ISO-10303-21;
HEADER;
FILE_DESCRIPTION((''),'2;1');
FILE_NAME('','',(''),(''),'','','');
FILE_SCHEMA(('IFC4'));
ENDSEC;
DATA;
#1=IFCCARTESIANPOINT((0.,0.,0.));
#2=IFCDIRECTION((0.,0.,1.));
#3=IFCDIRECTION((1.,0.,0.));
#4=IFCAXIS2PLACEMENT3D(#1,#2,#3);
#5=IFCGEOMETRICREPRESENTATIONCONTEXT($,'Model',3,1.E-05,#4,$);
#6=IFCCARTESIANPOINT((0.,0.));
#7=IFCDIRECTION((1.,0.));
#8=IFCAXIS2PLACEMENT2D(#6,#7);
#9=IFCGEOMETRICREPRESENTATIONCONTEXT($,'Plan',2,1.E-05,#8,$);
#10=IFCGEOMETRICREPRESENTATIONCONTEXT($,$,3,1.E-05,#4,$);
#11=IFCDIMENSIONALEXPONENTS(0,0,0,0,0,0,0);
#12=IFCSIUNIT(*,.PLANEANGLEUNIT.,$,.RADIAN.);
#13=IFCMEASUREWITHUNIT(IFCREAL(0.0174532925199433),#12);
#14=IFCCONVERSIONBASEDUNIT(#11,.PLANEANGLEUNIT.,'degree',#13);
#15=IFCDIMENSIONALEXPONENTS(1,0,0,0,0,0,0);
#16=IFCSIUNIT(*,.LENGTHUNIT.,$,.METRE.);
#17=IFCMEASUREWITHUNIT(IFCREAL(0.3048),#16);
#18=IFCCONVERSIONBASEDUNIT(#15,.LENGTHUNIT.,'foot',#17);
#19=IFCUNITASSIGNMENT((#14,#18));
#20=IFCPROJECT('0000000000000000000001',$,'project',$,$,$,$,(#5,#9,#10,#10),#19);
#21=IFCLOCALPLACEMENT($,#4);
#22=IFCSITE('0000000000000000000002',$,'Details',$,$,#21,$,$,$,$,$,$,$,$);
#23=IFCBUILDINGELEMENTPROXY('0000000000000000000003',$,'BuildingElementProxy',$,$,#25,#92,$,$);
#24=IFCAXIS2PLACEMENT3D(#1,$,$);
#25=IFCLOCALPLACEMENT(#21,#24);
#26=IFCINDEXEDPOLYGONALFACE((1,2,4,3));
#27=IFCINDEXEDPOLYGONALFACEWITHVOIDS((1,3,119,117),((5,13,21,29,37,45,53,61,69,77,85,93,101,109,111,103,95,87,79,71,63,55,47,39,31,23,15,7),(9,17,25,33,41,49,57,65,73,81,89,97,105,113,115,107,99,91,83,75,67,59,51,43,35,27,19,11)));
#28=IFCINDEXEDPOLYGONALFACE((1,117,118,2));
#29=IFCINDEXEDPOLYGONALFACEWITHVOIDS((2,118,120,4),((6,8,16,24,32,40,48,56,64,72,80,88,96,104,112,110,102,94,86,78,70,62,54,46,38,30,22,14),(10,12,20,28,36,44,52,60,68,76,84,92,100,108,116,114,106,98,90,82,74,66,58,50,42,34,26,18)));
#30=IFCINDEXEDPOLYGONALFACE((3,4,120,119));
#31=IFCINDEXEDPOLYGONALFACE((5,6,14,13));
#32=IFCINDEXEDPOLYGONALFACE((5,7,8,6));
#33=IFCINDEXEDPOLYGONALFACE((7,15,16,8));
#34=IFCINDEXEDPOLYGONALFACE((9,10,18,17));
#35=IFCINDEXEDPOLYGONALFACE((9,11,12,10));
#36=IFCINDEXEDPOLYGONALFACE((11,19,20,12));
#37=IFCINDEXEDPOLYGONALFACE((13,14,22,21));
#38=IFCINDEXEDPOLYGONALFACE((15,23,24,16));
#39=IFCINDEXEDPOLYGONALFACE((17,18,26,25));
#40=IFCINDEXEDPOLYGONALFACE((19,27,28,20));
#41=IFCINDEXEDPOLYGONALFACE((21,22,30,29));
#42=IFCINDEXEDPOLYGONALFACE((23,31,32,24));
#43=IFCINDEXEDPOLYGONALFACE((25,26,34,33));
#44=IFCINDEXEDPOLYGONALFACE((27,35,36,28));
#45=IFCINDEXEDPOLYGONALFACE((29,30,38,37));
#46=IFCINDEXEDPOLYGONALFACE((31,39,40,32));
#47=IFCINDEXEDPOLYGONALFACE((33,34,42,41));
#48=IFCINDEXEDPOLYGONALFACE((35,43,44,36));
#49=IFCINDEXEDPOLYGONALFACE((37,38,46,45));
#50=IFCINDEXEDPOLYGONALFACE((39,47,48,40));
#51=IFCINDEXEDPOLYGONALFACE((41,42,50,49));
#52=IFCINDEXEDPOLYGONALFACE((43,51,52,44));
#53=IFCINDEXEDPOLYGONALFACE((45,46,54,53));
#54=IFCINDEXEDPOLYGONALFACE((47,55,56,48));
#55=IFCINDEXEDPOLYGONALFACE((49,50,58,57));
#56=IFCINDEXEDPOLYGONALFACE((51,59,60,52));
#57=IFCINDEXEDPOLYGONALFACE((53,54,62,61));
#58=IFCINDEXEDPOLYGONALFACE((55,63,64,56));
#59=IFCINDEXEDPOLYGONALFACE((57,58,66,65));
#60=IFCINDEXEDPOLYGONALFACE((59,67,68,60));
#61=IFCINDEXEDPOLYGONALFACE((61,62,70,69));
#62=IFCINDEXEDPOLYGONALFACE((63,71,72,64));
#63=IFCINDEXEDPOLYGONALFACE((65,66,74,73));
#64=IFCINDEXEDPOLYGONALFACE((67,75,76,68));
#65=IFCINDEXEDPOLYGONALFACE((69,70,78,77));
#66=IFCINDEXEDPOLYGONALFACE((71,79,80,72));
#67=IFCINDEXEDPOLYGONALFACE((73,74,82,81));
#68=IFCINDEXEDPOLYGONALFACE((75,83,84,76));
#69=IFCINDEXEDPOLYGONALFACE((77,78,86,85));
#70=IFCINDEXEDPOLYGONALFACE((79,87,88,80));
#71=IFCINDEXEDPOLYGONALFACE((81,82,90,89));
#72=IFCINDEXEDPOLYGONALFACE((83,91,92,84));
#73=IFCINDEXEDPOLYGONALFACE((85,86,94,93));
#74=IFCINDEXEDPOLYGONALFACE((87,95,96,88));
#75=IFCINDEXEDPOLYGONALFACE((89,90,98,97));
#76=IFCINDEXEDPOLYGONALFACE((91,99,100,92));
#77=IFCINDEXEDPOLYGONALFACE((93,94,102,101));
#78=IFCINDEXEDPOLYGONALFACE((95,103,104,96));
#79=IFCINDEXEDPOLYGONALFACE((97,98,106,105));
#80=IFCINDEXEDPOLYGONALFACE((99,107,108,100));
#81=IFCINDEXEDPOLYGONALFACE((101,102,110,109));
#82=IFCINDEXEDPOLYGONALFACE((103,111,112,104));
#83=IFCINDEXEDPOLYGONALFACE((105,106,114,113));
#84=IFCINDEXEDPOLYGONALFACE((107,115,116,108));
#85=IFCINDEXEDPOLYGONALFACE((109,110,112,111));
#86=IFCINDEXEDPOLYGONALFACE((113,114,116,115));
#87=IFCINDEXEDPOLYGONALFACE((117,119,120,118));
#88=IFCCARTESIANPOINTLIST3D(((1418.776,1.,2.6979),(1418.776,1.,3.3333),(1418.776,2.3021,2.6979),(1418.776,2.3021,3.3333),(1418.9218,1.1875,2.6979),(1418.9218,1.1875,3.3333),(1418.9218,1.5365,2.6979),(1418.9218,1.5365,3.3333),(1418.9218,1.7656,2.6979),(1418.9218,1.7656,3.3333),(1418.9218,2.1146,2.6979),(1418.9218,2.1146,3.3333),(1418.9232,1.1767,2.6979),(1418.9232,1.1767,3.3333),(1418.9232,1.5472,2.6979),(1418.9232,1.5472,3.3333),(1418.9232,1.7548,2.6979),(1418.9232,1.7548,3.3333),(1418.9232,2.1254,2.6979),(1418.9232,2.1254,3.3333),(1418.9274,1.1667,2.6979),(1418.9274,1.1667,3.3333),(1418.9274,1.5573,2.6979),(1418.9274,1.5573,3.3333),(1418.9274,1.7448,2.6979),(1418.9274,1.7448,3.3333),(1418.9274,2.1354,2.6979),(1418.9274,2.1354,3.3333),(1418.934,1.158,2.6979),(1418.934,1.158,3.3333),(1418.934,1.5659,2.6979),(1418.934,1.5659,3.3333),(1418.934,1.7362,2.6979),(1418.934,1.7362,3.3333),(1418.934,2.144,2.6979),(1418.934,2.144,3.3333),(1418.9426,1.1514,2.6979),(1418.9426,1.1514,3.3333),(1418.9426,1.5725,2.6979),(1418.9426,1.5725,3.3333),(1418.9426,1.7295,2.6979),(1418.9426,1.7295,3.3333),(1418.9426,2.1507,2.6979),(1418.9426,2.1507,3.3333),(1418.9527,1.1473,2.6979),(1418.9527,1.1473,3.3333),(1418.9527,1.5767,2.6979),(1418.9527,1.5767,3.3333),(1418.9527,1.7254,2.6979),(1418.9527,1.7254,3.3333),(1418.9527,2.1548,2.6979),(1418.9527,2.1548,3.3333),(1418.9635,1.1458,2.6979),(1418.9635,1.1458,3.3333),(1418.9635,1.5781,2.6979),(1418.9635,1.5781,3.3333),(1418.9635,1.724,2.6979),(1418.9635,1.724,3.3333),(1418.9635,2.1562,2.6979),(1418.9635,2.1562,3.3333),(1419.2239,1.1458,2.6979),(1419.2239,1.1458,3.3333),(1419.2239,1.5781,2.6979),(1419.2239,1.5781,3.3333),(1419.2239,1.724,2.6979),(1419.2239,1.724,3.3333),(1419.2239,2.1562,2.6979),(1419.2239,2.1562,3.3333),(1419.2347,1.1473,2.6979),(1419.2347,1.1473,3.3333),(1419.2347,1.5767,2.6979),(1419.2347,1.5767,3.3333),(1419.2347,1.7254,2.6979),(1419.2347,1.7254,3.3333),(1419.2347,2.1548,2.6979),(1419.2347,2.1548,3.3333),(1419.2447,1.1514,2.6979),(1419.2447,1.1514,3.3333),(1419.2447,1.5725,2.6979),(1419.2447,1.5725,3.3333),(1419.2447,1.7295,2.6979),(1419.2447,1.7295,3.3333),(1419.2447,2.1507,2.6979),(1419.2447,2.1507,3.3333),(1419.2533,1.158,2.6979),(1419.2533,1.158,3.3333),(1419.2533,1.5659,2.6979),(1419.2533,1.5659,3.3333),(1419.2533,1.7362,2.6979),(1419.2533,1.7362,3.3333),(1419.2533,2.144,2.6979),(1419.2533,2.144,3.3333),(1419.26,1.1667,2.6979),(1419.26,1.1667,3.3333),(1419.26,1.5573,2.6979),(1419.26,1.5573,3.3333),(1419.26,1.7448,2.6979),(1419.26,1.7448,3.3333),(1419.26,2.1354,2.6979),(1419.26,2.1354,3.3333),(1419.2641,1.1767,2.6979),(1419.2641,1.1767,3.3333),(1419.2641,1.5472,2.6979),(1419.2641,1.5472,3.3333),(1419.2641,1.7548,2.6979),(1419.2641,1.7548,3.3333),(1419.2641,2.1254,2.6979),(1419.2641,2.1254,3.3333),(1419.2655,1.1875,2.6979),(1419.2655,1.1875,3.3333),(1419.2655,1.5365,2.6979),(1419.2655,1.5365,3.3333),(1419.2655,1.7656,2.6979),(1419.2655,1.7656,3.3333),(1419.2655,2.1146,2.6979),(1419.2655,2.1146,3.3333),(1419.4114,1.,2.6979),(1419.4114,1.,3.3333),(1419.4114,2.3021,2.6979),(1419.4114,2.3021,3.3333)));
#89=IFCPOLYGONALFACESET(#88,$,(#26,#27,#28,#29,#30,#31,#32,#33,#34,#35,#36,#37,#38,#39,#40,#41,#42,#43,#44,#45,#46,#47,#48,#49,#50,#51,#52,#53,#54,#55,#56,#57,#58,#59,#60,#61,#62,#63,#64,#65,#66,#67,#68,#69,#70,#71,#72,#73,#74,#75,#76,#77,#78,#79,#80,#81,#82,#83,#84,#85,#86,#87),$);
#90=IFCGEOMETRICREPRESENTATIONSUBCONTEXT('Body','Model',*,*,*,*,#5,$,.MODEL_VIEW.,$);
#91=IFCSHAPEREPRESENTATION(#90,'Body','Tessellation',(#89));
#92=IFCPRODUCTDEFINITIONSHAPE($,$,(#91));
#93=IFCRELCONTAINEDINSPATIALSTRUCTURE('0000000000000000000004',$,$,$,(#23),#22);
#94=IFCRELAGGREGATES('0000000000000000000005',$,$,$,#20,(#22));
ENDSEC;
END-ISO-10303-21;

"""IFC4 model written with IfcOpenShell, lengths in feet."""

from ifc_helpers import new_model, entity, si_unit, converted_unit, frame, origin_with_axes, origin_2d_with_axis, place, context, subcontext, project, spatial, line, indexed_curve, outline, extrude, element, save


model = new_model("IFC4")

# Units and contexts
model_context = context("Model", 3, precision=1e-05, world=origin_with_axes())
plan_context = context("Plan", 2, precision=1e-05, world=origin_2d_with_axis())
context_of_model = context(None, 3, precision=1e-05, world=origin_with_axes())
body_context = subcontext(model_context, "Body", "Model", "MODEL_VIEW")
ifc_project = project(units=[converted_unit("PLANEANGLEUNIT", "degree", entity("IfcReal", 0.0174532925199433), si_unit("PLANEANGLEUNIT", "RADIAN"), dimensions=[0, 0, 0, 0, 0, 0, 0]), converted_unit("LENGTHUNIT", "foot", entity("IfcReal", 0.3048), si_unit("LENGTHUNIT", "METRE"), dimensions=[1, 0, 0, 0, 0, 0, 0])], contexts=[model_context, plan_context, context_of_model, context_of_model])

# Site
site_placement = place(None, origin_with_axes())
site = spatial("IfcSite", under=ifc_project, at=site_placement, Name="Details")

# Building element proxy
proxy_1_placement = place(site_placement, frame((1419.0936, 2.3021, 2.6979), z_axis=(0.0, 0.0, 1.0), x_axis=(0.0, 1.0, 0.0)))
element("IfcBuildingElementProxy", 1, at=proxy_1_placement, inside=site, Name="BuildingElementProxy", context=body_context, shape_type="SweptSolid", body=[
    extrude(outline(indexed_curve([(-0.3177, -0.651), (0.3177, -0.651), (0.3177, 0.651), (-0.3177, 0.651), (0.1719, -0.1146), (0.1719, -0.4635), (0.1705, -0.4743), (0.1663, -0.4844), (0.1597, -0.493), (0.151, -0.4996), (0.141, -0.5038), (0.1302, -0.5052), (-0.1302, -0.5052), (-0.141, -0.5038), (-0.151, -0.4996), (-0.1597, -0.493), (-0.1663, -0.4844), (-0.1705, -0.4743), (-0.1719, -0.4635), (-0.1719, -0.1146), (-0.1705, -0.1038), (-0.1663, -0.0938), (-0.1597, -0.0851), (-0.151, -0.0785), (-0.141, -0.0743), (-0.1302, -0.0729), (0.1302, -0.0729), (0.141, -0.0743), (0.151, -0.0785), (0.1597, -0.0851), (0.1663, -0.0938), (0.1705, -0.1038), (0.151, 0.0785), (0.141, 0.0743), (0.1302, 0.0729), (-0.1302, 0.0729), (-0.141, 0.0743), (-0.151, 0.0785), (-0.1597, 0.0851), (-0.1663, 0.0937), (-0.1705, 0.1038), (-0.1719, 0.1146), (-0.1719, 0.4635), (-0.1705, 0.4743), (-0.1663, 0.4844), (-0.1597, 0.493), (-0.151, 0.4996), (-0.141, 0.5038), (-0.1302, 0.5052), (0.1302, 0.5052), (0.141, 0.5038), (0.151, 0.4996), (0.1597, 0.493), (0.1663, 0.4844), (0.1705, 0.4743), (0.1719, 0.4635), (0.1719, 0.1146), (0.1705, 0.1038), (0.1663, 0.0937), (0.1597, 0.0851)], segments=[line(4, 3), line(3, 2), line(2, 1), line(1, 4)], self_intersect=False), holes=[indexed_curve([(-0.3177, -0.651), (0.3177, -0.651), (0.3177, 0.651), (-0.3177, 0.651), (0.1719, -0.1146), (0.1719, -0.4635), (0.1705, -0.4743), (0.1663, -0.4844), (0.1597, -0.493), (0.151, -0.4996), (0.141, -0.5038), (0.1302, -0.5052), (-0.1302, -0.5052), (-0.141, -0.5038), (-0.151, -0.4996), (-0.1597, -0.493), (-0.1663, -0.4844), (-0.1705, -0.4743), (-0.1719, -0.4635), (-0.1719, -0.1146), (-0.1705, -0.1038), (-0.1663, -0.0938), (-0.1597, -0.0851), (-0.151, -0.0785), (-0.141, -0.0743), (-0.1302, -0.0729), (0.1302, -0.0729), (0.141, -0.0743), (0.151, -0.0785), (0.1597, -0.0851), (0.1663, -0.0938), (0.1705, -0.1038), (0.151, 0.0785), (0.141, 0.0743), (0.1302, 0.0729), (-0.1302, 0.0729), (-0.141, 0.0743), (-0.151, 0.0785), (-0.1597, 0.0851), (-0.1663, 0.0937), (-0.1705, 0.1038), (-0.1719, 0.1146), (-0.1719, 0.4635), (-0.1705, 0.4743), (-0.1663, 0.4844), (-0.1597, 0.493), (-0.151, 0.4996), (-0.141, 0.5038), (-0.1302, 0.5052), (0.1302, 0.5052), (0.141, 0.5038), (0.151, 0.4996), (0.1597, 0.493), (0.1663, 0.4844), (0.1705, 0.4743), (0.1719, 0.4635), (0.1719, 0.1146), (0.1705, 0.1038), (0.1663, 0.0937), (0.1597, 0.0851)], segments=[line(20, 19), line(19, 18), line(18, 17), line(17, 16), line(16, 15), line(15, 14), line(14, 13), line(13, 12), line(12, 11), line(11, 10), line(10, 9), line(9, 8), line(8, 7), line(7, 6), line(6, 5), line(5, 32), line(32, 31), line(31, 30), line(30, 29), line(29, 28), line(28, 27), line(27, 26), line(26, 25), line(25, 24), line(24, 23), line(23, 22), line(22, 21), line(21, 20)], self_intersect=False), indexed_curve([(-0.3177, -0.651), (0.3177, -0.651), (0.3177, 0.651), (-0.3177, 0.651), (0.1719, -0.1146), (0.1719, -0.4635), (0.1705, -0.4743), (0.1663, -0.4844), (0.1597, -0.493), (0.151, -0.4996), (0.141, -0.5038), (0.1302, -0.5052), (-0.1302, -0.5052), (-0.141, -0.5038), (-0.151, -0.4996), (-0.1597, -0.493), (-0.1663, -0.4844), (-0.1705, -0.4743), (-0.1719, -0.4635), (-0.1719, -0.1146), (-0.1705, -0.1038), (-0.1663, -0.0938), (-0.1597, -0.0851), (-0.151, -0.0785), (-0.141, -0.0743), (-0.1302, -0.0729), (0.1302, -0.0729), (0.141, -0.0743), (0.151, -0.0785), (0.1597, -0.0851), (0.1663, -0.0938), (0.1705, -0.1038), (0.151, 0.0785), (0.141, 0.0743), (0.1302, 0.0729), (-0.1302, 0.0729), (-0.141, 0.0743), (-0.151, 0.0785), (-0.1597, 0.0851), (-0.1663, 0.0937), (-0.1705, 0.1038), (-0.1719, 0.1146), (-0.1719, 0.4635), (-0.1705, 0.4743), (-0.1663, 0.4844), (-0.1597, 0.493), (-0.151, 0.4996), (-0.141, 0.5038), (-0.1302, 0.5052), (0.1302, 0.5052), (0.141, 0.5038), (0.151, 0.4996), (0.1597, 0.493), (0.1663, 0.4844), (0.1705, 0.4743), (0.1719, 0.4635), (0.1719, 0.1146), (0.1705, 0.1038), (0.1663, 0.0937), (0.1597, 0.0851)], segments=[line(44, 43), line(43, 42), line(42, 41), line(41, 40), line(40, 39), line(39, 38), line(38, 37), line(37, 36), line(36, 35), line(35, 34), line(34, 33), line(33, 60), line(60, 59), line(59, 58), line(58, 57), line(57, 56), line(56, 55), line(55, 54), line(54, 53), line(53, 52), line(52, 51), line(51, 50), line(50, 49), line(49, 48), line(48, 47), line(47, 46), line(46, 45), line(45, 44)], self_intersect=False)]), frame((-0.651, 0.0, 0.0), z_axis=(0.0, 0.0, 1.0), x_axis=(0.0, -1.0, 0.0)), (0.0, 0.0, 1.0), 0.6354),
])

save(model, "model.ifc")
